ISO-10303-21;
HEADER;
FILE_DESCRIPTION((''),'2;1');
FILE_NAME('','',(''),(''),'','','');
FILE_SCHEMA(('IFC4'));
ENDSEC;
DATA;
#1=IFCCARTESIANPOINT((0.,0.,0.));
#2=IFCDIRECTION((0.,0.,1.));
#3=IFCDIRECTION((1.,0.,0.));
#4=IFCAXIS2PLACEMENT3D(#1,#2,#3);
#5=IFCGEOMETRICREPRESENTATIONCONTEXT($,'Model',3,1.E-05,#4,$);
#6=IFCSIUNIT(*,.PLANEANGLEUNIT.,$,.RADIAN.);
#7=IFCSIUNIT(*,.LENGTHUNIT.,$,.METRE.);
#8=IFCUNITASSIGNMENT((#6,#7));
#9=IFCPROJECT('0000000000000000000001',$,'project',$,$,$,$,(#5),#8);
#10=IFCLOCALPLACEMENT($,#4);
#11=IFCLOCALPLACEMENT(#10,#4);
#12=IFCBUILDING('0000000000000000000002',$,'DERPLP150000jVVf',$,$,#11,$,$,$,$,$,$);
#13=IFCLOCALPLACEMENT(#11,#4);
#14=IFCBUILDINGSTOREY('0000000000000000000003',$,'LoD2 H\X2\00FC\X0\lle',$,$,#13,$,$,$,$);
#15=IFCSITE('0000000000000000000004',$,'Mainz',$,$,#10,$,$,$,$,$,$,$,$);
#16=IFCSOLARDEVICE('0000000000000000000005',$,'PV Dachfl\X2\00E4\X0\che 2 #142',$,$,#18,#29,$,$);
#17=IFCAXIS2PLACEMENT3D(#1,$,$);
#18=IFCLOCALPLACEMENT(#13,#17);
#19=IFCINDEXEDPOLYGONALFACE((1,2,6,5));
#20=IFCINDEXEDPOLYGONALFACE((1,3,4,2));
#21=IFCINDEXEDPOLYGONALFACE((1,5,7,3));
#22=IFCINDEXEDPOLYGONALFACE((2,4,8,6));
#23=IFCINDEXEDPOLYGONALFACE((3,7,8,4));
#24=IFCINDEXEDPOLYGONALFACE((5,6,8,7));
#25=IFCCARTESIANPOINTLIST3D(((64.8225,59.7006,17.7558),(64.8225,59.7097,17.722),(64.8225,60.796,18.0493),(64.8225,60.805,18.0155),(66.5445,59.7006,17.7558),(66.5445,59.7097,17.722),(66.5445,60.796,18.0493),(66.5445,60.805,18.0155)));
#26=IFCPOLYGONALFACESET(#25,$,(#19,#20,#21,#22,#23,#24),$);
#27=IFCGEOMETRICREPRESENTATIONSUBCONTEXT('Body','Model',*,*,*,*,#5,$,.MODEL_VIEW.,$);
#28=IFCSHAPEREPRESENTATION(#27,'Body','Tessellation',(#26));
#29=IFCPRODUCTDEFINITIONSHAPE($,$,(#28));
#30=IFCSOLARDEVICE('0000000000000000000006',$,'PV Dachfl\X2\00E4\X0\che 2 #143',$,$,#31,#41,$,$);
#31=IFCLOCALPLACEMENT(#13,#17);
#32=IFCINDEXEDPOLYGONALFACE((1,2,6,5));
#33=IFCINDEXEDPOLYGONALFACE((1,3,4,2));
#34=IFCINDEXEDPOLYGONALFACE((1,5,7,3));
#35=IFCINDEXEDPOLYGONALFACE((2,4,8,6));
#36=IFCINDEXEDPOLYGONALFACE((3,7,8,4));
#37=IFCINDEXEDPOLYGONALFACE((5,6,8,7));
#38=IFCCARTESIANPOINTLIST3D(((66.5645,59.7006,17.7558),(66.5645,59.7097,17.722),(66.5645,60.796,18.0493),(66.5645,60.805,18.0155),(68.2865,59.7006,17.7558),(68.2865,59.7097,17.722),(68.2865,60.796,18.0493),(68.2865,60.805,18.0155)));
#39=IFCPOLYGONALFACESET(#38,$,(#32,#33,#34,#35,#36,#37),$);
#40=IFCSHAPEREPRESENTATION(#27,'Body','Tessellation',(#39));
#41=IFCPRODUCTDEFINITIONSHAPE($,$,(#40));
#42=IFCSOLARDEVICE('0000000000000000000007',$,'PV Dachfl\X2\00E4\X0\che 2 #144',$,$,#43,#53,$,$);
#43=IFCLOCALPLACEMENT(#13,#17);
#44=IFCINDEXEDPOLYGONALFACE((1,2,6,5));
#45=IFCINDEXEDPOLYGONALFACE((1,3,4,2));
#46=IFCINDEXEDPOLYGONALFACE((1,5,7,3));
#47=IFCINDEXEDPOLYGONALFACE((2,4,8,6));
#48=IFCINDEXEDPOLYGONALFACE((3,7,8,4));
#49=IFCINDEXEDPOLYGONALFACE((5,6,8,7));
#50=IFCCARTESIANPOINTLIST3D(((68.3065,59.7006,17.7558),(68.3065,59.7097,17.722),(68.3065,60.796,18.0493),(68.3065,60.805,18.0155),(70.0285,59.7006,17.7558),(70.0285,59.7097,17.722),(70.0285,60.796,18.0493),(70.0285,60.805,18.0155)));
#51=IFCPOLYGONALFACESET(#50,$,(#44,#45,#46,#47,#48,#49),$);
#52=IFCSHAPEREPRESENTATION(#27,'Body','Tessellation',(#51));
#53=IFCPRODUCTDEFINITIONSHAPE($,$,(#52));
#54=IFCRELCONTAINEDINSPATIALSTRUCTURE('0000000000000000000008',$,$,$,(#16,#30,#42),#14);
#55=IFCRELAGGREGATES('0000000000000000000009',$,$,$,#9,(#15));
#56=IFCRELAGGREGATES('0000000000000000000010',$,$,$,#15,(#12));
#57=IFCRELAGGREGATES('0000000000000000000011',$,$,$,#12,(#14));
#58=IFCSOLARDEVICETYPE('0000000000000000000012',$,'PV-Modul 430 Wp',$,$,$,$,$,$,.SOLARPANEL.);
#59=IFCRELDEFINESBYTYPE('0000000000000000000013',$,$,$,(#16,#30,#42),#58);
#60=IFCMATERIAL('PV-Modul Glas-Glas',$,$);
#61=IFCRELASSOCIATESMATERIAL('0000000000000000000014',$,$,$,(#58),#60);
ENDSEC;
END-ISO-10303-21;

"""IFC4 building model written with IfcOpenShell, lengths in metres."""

from ifc_helpers import new_model, si_unit, frame, frame_2d, origin, origin_with_axes, place, context, subcontext, project, spatial, rectangle, extrude, source, transform, mapped, material, type_object, type_shapes, element, save


model = new_model("IFC4")

# Units and contexts
model_context = context("Model", 3, precision=1e-05, world=origin_with_axes())
body_context = subcontext(model_context, "Body", "Model", "MODEL_VIEW")
ifc_project = project(units=[si_unit("PLANEANGLEUNIT", "RADIAN"), si_unit("LENGTHUNIT", "METRE")], contexts=[model_context])

# Site, building, storey
site_placement = place(None, origin_with_axes())
site = spatial("IfcSite", under=ifc_project, at=site_placement, Name="Mainz")
building_placement = place(site_placement, origin_with_axes())
building = spatial("IfcBuilding", under=site, at=building_placement, Name="DERPLP150000jVVf")
storey_placement = place(building_placement, origin_with_axes())
storey = spatial("IfcBuildingStorey", under=building, at=storey_placement, Name="LoD2 Hülle")

# Solar devices
ifc_material = material(Name="PV-Modul Glas-Glas")
solar_device_type = type_object("IfcSolarDeviceType", Name="PV-Modul 430 Wp", PredefinedType="SOLARPANEL", material=ifc_material)
shared_shape = source(origin_with_axes(), body_context, "Body", "SweptSolid", [
    extrude(rectangle(XDim=1.722, YDim=1.134, at=frame_2d((0.861, 0.567))), origin(), (0.0, 0.0, 1.0), 0.035),
])
type_shapes(solar_device_type, [shared_shape])
for number, where, z_axis, x_axis, name in (
    (1, (64.8225, 59.7097, 17.722), (0.0, -0.258819, 0.965926), (1.0, 0.0, 0.0), "PV Dachfläche 2 #142"),
    (2, (66.5645, 59.7097, 17.722), (0.0, -0.258819, 0.965926), (1.0, 0.0, 0.0), "PV Dachfläche 2 #143"),
    (3, (68.3065, 59.7097, 17.722), (0.0, -0.258819, 0.965926), (1.0, 0.0, 0.0), "PV Dachfläche 2 #144"),
):
    element("IfcSolarDevice", number, at=place(storey_placement, frame(where, z_axis=z_axis, x_axis=x_axis)), inside=storey, type_object=solar_device_type, Name=name, context=body_context, shape_type="MappedRepresentation", body=[
        mapped(shared_shape, transform((0.0, 0.0, 0.0), x_axis=(1.0, 0.0, 0.0), y_axis=(0.0, 1.0, 0.0), z_axis=(0.0, 0.0, 1.0), scale=1.0)),
    ])

save(model, "model.ifc")
